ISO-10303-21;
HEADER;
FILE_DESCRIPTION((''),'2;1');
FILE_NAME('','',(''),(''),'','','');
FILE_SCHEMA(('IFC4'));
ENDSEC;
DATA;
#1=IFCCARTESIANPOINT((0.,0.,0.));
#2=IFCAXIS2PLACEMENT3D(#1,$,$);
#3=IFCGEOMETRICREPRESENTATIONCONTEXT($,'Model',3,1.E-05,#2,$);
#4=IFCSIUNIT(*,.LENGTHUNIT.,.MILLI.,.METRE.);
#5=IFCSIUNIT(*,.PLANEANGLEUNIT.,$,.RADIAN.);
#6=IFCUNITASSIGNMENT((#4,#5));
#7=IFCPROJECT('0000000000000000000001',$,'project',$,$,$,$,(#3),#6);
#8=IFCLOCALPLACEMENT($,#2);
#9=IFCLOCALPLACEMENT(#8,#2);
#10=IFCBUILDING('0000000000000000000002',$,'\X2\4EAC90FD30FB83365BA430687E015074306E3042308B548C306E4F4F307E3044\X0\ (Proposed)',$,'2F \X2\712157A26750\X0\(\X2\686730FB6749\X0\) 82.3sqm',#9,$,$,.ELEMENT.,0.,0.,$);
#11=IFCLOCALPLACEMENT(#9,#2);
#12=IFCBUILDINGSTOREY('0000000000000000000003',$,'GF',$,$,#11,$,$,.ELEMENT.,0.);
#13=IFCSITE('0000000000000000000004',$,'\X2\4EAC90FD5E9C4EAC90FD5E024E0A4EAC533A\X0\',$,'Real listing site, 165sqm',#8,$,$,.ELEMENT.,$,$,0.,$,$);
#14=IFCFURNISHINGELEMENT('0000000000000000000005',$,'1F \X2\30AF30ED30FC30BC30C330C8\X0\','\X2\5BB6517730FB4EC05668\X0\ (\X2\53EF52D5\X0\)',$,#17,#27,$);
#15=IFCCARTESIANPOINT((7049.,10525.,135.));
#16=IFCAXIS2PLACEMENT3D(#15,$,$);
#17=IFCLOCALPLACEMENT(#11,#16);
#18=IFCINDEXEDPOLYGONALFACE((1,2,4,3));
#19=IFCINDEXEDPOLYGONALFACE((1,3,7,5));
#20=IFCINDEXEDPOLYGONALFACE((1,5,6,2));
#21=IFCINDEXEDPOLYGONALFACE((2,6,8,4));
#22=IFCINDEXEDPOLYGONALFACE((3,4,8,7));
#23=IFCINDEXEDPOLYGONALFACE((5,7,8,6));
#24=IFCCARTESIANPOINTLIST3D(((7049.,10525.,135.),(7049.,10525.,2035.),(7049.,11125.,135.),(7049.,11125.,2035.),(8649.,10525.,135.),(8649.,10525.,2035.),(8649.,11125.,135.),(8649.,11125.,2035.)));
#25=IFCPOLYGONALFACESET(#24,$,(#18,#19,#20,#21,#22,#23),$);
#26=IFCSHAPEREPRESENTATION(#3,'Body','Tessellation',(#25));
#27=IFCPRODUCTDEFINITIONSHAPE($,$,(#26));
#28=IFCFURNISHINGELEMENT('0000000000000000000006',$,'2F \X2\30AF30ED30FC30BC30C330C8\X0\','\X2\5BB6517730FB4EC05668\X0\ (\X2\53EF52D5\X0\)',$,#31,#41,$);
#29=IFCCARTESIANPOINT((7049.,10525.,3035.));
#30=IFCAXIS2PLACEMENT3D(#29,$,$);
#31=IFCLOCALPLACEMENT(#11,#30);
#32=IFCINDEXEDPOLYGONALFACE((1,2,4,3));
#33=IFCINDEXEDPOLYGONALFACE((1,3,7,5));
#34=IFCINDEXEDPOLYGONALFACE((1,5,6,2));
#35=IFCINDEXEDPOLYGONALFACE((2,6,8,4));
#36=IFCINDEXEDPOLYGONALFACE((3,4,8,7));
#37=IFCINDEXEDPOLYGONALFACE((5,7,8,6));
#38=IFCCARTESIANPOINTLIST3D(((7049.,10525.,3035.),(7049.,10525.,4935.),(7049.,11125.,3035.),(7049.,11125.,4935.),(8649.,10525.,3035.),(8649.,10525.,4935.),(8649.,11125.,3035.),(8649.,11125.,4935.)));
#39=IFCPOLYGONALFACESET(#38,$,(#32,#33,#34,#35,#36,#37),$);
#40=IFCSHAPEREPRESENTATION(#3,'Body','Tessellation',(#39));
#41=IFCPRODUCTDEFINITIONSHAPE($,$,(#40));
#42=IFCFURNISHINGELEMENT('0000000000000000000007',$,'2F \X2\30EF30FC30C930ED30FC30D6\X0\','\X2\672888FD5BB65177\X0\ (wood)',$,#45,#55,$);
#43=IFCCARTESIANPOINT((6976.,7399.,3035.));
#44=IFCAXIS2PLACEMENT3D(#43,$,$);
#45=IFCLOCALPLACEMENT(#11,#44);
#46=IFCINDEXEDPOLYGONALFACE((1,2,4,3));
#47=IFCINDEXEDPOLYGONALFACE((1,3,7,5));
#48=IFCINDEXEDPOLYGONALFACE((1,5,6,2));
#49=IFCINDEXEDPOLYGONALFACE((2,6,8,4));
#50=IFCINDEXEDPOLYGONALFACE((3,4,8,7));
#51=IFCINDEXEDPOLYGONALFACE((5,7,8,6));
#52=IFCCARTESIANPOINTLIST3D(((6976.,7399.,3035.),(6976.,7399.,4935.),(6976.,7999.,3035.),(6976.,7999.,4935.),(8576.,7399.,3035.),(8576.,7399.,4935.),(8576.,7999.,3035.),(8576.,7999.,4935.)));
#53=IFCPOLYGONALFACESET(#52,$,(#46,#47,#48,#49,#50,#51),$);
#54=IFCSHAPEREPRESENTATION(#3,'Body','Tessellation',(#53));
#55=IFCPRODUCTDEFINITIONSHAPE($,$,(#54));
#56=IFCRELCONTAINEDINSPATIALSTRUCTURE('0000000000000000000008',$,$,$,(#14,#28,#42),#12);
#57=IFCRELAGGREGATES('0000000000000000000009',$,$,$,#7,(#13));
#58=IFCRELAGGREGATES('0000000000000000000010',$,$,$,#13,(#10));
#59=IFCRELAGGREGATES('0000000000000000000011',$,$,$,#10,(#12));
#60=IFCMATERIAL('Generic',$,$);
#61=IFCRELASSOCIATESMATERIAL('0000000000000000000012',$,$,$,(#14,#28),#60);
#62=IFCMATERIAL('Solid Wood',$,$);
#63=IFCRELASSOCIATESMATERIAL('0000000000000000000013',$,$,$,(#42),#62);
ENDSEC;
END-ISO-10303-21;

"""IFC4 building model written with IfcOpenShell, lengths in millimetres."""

from ifc_helpers import new_model, si_unit, frame, frame_2d, origin, place, context, project, spatial, rectangle, extrude, material, element, save


model = new_model("IFC4")

# Units and contexts
model_context = context("Model", 3, precision=1e-05, world=origin())
ifc_project = project(units=[si_unit("LENGTHUNIT", "METRE", prefix="MILLI"), si_unit("PLANEANGLEUNIT", "RADIAN")], contexts=[model_context])

# Site, building, storey
site_placement = place(None, origin())
site = spatial("IfcSite", under=ifc_project, at=site_placement, Name="京都府京都市上京区", ObjectType="Real listing site, 165sqm", CompositionType="ELEMENT", RefElevation=0.0)
building_placement = place(site_placement, origin())
building = spatial("IfcBuilding", under=site, at=building_placement, Name="京都・茶室と縁側のある和の住まい (Proposed)", ObjectType="2F 無垢材(桧・杉) 82.3sqm", CompositionType="ELEMENT", ElevationOfRefHeight=0.0, ElevationOfTerrain=0.0)
storey_placement = place(building_placement, origin())
storey = spatial("IfcBuildingStorey", under=building, at=storey_placement, Name="GF", CompositionType="ELEMENT", Elevation=0.0)

# Shared definitions
ifc_material_1 = material(Name="Solid Wood")

# Shared definitions
ifc_material_2 = material(Name="Generic")

# Furnishing elements
furnishing_1_placement = place(storey_placement, frame((7049.0, 10525.0, 135.0)))
element("IfcFurnishingElement", 1, at=furnishing_1_placement, inside=storey, material=ifc_material_2, Name="1F クローゼット", Description="家具・什器 (可動)", context=model_context, shape_type="SweptSolid", body=[
    extrude(rectangle(XDim=1600.0, YDim=600.0, at=frame_2d((800.0, 300.0))), frame((7049.0, 10525.0, 135.0)), (0.0, 0.0, 1.0), 1900.0),
])
furnishing_2_placement = place(storey_placement, frame((7049.0, 10525.0, 3035.0)))
element("IfcFurnishingElement", 2, at=furnishing_2_placement, inside=storey, material=ifc_material_2, Name="2F クローゼット", Description="家具・什器 (可動)", context=model_context, shape_type="SweptSolid", body=[
    extrude(rectangle(XDim=1600.0, YDim=600.0, at=frame_2d((800.0, 300.0))), frame((7049.0, 10525.0, 3035.0)), (0.0, 0.0, 1.0), 1900.0),
])
furnishing_3_placement = place(storey_placement, frame((6976.0, 7399.0, 3035.0)))
element("IfcFurnishingElement", 3, at=furnishing_3_placement, inside=storey, material=ifc_material_1, Name="2F ワードローブ", Description="木製家具 (wood)", context=model_context, shape_type="SweptSolid", body=[
    extrude(rectangle(XDim=1600.0, YDim=600.0, at=frame_2d((800.0, 300.0))), frame((6976.0, 7399.0, 3035.0)), (0.0, 0.0, 1.0), 1900.0),
])

save(model, "model.ifc")
